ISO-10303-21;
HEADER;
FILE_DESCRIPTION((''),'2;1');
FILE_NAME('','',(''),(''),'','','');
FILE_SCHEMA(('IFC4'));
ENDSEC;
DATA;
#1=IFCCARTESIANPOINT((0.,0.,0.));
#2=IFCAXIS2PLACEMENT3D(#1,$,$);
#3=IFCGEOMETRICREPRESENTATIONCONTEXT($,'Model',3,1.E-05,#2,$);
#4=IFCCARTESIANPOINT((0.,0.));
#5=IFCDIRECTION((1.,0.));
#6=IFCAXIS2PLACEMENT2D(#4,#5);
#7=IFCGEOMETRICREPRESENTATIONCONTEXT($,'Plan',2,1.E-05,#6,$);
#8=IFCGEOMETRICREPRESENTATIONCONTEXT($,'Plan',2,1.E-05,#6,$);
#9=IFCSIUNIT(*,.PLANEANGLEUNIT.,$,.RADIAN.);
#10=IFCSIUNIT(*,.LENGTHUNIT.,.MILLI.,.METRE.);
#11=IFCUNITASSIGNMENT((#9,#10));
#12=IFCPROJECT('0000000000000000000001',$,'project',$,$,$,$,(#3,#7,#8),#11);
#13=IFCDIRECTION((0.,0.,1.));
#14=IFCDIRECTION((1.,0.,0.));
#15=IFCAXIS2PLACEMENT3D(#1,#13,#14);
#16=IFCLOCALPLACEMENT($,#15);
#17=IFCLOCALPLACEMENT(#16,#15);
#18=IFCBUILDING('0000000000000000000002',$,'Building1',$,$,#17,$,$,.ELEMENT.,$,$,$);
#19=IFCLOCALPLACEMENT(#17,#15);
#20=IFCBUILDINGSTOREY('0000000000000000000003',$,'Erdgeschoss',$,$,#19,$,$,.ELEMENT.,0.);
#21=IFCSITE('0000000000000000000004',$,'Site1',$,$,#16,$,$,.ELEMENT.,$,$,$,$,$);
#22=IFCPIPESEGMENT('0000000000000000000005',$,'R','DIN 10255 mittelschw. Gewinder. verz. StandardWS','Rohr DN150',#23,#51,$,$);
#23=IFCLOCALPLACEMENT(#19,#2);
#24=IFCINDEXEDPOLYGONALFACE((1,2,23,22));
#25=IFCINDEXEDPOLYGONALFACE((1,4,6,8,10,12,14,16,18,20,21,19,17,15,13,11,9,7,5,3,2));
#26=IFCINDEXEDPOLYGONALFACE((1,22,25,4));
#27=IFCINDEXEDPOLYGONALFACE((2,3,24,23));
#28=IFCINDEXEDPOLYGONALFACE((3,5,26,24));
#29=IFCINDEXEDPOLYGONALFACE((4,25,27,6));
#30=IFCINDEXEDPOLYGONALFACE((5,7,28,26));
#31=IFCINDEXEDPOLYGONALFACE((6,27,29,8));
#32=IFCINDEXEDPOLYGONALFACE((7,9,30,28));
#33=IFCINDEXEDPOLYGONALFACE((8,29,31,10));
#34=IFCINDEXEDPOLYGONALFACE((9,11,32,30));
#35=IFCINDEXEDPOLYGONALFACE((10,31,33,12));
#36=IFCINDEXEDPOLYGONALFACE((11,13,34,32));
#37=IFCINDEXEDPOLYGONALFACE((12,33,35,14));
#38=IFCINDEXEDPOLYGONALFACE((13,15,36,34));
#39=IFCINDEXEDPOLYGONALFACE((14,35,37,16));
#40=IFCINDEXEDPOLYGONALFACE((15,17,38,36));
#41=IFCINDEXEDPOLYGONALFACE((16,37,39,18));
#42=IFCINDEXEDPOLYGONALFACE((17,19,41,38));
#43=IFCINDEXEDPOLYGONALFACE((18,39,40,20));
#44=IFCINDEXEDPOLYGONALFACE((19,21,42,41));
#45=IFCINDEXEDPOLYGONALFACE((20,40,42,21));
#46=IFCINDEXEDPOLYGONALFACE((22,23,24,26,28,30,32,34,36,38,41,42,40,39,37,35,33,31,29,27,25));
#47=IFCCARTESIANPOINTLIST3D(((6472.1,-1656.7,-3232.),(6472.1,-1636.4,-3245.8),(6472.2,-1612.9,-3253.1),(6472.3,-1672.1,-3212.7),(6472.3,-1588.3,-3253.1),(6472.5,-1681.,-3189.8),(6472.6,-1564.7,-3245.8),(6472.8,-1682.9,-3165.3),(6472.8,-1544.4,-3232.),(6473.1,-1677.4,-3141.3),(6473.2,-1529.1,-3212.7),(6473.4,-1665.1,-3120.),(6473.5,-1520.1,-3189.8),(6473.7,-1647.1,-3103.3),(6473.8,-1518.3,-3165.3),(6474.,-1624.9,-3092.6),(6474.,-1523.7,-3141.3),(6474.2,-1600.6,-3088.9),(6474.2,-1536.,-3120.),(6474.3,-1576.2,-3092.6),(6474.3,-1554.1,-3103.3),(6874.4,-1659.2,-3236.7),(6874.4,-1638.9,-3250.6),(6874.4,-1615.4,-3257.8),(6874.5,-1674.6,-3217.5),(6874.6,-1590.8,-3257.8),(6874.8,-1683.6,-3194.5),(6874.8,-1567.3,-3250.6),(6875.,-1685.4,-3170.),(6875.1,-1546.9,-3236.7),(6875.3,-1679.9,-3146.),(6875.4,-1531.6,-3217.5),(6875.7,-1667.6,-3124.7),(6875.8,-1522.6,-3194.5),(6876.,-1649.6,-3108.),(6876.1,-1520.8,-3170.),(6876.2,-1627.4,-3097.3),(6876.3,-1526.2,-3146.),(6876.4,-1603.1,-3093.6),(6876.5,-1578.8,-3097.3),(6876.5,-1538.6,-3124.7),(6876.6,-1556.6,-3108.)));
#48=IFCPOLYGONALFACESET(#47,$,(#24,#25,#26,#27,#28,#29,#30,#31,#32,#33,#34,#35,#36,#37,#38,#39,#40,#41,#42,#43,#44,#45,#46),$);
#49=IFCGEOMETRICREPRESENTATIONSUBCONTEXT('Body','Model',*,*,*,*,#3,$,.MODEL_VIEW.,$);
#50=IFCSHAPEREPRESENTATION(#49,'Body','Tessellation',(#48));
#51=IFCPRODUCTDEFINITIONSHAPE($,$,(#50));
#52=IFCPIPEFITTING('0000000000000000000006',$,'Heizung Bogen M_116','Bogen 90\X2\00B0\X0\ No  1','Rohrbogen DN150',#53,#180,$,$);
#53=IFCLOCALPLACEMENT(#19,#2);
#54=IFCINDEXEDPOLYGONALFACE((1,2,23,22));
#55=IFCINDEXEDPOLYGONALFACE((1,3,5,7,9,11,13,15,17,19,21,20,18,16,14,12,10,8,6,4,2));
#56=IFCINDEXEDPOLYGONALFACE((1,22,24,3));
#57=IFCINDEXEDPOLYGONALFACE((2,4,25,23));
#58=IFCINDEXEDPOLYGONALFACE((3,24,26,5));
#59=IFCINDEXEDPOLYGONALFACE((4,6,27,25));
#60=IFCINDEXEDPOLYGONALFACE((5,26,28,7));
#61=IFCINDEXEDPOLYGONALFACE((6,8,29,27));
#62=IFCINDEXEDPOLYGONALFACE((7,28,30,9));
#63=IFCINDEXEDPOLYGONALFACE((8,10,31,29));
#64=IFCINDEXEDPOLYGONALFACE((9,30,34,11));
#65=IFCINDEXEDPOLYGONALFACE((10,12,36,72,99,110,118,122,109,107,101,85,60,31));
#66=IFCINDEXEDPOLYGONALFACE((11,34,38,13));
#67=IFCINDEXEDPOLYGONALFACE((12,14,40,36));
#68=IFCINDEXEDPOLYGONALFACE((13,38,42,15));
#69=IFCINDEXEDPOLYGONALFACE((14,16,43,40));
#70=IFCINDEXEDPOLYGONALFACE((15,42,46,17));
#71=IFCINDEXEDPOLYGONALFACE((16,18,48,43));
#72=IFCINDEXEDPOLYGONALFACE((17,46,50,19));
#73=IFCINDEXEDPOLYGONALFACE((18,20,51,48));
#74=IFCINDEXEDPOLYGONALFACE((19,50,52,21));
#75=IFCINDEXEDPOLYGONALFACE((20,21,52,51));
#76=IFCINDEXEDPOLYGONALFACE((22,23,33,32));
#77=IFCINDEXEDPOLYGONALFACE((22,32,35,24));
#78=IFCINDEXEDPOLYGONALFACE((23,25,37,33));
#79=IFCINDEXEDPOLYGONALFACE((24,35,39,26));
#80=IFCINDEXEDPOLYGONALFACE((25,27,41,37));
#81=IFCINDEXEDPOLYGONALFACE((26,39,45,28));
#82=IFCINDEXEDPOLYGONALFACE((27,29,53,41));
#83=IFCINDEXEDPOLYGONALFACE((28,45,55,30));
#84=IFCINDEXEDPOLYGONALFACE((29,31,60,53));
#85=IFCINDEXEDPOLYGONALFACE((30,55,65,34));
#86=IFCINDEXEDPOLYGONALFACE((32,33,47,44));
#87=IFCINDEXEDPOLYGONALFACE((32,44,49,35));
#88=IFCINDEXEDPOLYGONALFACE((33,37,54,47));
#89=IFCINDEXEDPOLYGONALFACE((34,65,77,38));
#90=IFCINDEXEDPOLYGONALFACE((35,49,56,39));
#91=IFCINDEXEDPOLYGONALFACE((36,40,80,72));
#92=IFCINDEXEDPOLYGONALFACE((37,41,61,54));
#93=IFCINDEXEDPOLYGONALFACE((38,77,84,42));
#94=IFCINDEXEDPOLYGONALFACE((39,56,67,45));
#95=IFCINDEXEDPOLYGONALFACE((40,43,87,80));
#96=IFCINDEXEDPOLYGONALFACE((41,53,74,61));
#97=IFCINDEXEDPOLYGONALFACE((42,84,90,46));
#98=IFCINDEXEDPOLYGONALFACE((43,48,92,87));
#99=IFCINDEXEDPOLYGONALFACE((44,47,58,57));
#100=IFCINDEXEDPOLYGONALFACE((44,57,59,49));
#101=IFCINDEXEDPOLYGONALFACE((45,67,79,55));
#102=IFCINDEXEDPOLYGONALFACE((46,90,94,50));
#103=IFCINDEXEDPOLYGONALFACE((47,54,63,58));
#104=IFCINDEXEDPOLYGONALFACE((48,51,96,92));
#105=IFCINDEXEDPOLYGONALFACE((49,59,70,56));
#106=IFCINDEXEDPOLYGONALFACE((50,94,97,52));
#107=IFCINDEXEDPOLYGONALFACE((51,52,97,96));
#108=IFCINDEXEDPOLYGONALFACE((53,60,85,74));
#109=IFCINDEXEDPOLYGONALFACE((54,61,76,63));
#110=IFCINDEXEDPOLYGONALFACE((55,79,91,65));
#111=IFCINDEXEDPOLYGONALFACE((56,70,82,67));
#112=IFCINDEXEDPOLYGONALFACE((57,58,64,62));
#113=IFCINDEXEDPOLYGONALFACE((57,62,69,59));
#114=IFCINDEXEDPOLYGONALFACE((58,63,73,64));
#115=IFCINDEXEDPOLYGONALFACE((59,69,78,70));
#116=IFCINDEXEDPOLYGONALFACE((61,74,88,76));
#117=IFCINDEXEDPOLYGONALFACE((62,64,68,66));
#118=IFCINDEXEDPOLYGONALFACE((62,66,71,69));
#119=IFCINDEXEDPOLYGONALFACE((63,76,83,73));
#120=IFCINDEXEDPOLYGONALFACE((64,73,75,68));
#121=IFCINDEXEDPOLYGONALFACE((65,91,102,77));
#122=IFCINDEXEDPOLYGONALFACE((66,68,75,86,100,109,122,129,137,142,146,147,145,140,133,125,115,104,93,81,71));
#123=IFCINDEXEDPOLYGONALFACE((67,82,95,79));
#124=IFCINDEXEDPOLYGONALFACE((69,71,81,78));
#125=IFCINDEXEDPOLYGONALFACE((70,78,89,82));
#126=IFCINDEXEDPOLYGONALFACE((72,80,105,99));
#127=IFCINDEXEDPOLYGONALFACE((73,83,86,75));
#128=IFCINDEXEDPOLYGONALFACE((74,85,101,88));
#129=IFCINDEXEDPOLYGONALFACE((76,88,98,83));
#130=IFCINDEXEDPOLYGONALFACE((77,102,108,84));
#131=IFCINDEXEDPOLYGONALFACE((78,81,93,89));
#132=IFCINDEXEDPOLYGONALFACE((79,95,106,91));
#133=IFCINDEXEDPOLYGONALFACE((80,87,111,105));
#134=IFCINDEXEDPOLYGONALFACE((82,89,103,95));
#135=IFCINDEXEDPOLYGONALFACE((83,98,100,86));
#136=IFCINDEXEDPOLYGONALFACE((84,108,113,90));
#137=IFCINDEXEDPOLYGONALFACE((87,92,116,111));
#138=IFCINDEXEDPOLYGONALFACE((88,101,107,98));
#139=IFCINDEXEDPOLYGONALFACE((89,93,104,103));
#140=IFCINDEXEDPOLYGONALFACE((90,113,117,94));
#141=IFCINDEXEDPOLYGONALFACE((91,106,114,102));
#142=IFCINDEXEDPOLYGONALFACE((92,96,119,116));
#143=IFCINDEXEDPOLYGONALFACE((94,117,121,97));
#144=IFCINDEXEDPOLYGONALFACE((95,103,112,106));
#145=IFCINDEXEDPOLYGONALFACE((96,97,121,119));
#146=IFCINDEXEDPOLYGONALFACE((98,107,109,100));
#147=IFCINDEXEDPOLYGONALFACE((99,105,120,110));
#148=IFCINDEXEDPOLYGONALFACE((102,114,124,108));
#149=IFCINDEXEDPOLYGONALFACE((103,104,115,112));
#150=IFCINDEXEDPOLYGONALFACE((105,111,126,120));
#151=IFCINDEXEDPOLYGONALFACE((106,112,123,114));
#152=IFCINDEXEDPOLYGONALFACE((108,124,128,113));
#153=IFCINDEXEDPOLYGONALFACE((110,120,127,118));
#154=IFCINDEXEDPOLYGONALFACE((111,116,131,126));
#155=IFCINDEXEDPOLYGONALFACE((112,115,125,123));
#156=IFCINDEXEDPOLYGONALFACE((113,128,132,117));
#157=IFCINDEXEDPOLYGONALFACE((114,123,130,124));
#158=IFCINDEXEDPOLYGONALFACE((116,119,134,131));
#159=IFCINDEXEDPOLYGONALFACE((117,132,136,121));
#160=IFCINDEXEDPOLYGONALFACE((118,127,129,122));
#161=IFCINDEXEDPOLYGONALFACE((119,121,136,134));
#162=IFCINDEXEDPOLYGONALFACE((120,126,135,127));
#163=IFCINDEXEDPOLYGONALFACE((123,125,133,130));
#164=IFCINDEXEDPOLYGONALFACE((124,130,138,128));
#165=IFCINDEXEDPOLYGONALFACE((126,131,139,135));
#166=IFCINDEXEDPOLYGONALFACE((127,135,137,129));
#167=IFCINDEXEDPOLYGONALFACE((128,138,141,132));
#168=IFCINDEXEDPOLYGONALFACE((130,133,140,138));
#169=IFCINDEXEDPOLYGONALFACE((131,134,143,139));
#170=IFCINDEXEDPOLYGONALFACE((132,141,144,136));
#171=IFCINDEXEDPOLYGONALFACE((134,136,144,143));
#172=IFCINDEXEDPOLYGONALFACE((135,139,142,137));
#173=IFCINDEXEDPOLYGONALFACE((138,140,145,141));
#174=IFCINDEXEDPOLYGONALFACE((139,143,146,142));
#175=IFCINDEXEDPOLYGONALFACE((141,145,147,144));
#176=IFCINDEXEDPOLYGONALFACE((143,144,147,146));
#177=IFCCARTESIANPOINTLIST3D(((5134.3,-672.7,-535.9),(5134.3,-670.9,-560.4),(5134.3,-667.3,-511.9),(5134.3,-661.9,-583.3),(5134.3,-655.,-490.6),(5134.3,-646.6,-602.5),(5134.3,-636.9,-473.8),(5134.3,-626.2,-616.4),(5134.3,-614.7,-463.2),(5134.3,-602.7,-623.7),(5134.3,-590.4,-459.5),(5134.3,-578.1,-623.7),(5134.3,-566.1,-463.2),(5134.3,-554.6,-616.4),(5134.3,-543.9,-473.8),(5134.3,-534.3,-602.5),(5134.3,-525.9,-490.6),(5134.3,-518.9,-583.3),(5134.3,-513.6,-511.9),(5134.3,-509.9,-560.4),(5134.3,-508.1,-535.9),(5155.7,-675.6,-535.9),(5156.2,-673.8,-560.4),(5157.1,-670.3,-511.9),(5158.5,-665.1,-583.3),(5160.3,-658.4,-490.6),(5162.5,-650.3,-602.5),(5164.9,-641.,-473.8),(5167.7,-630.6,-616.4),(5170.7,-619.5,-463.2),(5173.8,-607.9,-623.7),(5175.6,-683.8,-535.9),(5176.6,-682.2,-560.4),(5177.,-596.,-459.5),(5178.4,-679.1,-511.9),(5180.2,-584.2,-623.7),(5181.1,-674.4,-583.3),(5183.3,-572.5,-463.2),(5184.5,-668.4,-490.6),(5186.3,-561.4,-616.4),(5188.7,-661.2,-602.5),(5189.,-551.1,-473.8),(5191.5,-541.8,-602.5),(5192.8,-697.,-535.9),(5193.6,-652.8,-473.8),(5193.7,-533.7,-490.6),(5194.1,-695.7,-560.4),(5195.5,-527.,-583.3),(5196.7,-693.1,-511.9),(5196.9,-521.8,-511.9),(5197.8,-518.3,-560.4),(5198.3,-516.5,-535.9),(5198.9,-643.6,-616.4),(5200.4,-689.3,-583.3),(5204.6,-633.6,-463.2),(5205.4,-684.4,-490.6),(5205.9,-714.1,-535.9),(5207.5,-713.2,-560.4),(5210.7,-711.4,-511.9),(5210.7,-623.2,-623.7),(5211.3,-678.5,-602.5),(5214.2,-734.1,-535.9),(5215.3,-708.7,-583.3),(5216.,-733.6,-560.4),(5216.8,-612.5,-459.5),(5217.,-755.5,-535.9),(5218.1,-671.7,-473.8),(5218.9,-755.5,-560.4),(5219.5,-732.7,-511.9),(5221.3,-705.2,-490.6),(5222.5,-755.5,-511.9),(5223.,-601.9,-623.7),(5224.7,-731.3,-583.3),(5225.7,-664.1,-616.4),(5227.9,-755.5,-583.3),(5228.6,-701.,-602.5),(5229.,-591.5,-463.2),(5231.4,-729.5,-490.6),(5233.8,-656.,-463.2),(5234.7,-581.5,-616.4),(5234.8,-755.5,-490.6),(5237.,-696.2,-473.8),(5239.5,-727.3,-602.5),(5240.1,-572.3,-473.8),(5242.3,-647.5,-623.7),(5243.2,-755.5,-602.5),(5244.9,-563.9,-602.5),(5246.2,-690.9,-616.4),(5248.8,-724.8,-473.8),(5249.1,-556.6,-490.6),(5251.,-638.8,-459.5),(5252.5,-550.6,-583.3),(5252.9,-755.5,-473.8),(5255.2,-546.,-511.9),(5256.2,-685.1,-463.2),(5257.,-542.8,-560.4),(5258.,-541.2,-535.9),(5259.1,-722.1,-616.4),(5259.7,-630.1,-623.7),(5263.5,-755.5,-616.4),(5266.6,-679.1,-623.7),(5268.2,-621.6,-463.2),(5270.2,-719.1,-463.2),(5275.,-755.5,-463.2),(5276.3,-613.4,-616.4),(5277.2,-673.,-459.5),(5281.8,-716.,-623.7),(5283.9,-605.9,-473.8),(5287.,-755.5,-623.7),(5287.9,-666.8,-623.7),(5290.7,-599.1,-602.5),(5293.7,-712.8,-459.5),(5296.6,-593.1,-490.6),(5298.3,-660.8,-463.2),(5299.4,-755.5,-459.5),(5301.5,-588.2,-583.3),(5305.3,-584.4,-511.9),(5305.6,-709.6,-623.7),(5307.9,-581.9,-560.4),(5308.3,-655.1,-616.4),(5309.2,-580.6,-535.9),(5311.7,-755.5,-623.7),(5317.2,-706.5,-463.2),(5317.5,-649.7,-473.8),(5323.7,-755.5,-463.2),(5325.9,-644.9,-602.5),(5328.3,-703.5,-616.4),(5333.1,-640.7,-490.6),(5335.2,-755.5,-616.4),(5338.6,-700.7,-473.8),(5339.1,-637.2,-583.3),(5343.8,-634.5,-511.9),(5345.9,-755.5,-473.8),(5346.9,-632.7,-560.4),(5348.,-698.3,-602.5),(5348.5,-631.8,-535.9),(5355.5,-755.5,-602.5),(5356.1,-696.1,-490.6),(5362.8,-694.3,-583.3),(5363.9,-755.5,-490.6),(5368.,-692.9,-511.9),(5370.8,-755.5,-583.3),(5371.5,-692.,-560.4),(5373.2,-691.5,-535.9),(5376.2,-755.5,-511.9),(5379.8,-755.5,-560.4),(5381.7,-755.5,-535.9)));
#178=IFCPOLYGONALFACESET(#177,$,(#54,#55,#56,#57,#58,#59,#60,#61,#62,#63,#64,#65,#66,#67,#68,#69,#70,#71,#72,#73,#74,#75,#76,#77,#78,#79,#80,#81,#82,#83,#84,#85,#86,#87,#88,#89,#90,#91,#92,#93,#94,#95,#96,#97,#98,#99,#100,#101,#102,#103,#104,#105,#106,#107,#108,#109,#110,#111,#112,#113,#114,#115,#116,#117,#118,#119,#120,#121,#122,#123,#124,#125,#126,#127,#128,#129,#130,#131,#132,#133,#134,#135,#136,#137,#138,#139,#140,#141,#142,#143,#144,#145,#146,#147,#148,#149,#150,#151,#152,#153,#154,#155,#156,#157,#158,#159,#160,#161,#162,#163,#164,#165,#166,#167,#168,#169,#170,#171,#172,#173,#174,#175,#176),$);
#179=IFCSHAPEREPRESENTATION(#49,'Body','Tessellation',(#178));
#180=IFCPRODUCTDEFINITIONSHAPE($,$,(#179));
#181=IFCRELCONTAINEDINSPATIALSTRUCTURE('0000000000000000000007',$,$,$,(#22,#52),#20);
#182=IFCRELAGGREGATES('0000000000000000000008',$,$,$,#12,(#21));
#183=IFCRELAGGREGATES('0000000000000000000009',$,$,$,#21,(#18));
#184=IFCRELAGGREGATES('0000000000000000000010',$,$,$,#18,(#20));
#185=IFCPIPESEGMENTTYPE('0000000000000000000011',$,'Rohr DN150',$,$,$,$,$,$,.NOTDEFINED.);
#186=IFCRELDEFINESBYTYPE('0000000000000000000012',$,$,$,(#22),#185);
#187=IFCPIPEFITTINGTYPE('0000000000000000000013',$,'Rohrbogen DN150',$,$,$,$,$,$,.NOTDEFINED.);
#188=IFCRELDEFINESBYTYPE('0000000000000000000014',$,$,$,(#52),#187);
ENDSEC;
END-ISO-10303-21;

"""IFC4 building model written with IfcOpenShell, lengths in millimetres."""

from ifc_helpers import new_model, entity, si_unit, frame, origin, origin_with_axes, origin_2d_with_axis, place, context, subcontext, project, spatial, circle, extrude, source, transform, mapped, type_object, element, save


model = new_model("IFC4")

# Units and contexts
model_context = context("Model", 3, precision=1e-05, world=origin())
plan_context_1 = context("Plan", 2, precision=1e-05, world=origin_2d_with_axis())
plan_context_2 = context("Plan", 2, precision=1e-05, world=origin_2d_with_axis())
body_context = subcontext(model_context, "Body", "Model", "MODEL_VIEW")
ifc_project = project(units=[si_unit("PLANEANGLEUNIT", "RADIAN"), si_unit("LENGTHUNIT", "METRE", prefix="MILLI")], contexts=[model_context, plan_context_1, plan_context_2])

# Site, building, storey
site_placement = place(None, origin_with_axes())
site = spatial("IfcSite", under=ifc_project, at=site_placement, Name="Site1", CompositionType="ELEMENT")
building_placement = place(site_placement, origin_with_axes())
building = spatial("IfcBuilding", under=site, at=building_placement, Name="Building1", CompositionType="ELEMENT")
storey_placement = place(building_placement, origin_with_axes())
storey = spatial("IfcBuildingStorey", under=building, at=storey_placement, Name="Erdgeschoss", CompositionType="ELEMENT", Elevation=0.0)

# Pipe segment
pipe_segment_type_1 = type_object("IfcPipeSegmentType", Name="Rohr DN150", PredefinedType="NOTDEFINED")
pipe_segment_1_placement = place(storey_placement, frame((6674.3, -1602.0, -3173.8), z_axis=(0.0, 0.0, 1.0), x_axis=(1.0, 0.0, 0.0)))
element("IfcPipeSegment", 1, at=pipe_segment_1_placement, inside=storey, type_object=pipe_segment_type_1, Name="R", Description="DIN 10255 mittelschw. Gewinder. verz. StandardWS", ObjectType="Rohr DN150", context=body_context, shape_type="SolidModel", body=[
    extrude(circle(Radius=82.5, at=origin_2d_with_axis()), frame((201.1, -1.1, -2.4), z_axis=(-0.999912, 0.00627, 0.011706), x_axis=(0.0, 0.0, 1.0)), (0.0, 0.0, 1.0), 402.3),
])

# Pipe fitting
pipe_fitting_type_1 = type_object("IfcPipeFittingType", Name="Rohrbogen DN150", PredefinedType="NOTDEFINED")
shared_shape_1 = source(origin_with_axes(), body_context, "Body", "SolidModel", [
    entity("IfcRevolvedAreaSolid", entity("IfcCircleProfileDef", "AREA", None, entity("IfcAxis2Placement2D", entity("IfcCartesianPoint", [0.0, 0.0]), entity("IfcDirection", [1.0, 0.0])), 82.5), entity("IfcAxis2Placement3D", entity("IfcCartesianPoint", [-123.8, 41.3, 0.0]), entity("IfcDirection", [1.0, 0.0, 0.0]), entity("IfcDirection", [0.0, 0.0, 1.0])), entity("IfcAxis1Placement", entity("IfcCartesianPoint", [0.0, 165.1, 0.0]), entity("IfcDirection", [-1.0, 0.0, 0.0])), 1.570796),
])
pipe_fitting_1_placement = place(storey_placement, frame((5258.1, -631.7, -542.0), z_axis=(0.0, 0.0, 1.0), x_axis=(1.0, 0.0, 0.0)))
element("IfcPipeFitting", 2, at=pipe_fitting_1_placement, inside=storey, type_object=pipe_fitting_type_1, Name="Heizung Bogen M_116", Description="Bogen 90° No  1", ObjectType="Rohrbogen DN150", context=body_context, shape_type="MappedRepresentation", body=[
    mapped(shared_shape_1, transform((0.0, 0.0, 0.0), x_axis=(1.0, 0.0, 0.0), y_axis=(0.0, 1.0, 0.0), z_axis=(0.0, 0.0, 1.0), scale=1.0)),
])

save(model, "model.ifc")
